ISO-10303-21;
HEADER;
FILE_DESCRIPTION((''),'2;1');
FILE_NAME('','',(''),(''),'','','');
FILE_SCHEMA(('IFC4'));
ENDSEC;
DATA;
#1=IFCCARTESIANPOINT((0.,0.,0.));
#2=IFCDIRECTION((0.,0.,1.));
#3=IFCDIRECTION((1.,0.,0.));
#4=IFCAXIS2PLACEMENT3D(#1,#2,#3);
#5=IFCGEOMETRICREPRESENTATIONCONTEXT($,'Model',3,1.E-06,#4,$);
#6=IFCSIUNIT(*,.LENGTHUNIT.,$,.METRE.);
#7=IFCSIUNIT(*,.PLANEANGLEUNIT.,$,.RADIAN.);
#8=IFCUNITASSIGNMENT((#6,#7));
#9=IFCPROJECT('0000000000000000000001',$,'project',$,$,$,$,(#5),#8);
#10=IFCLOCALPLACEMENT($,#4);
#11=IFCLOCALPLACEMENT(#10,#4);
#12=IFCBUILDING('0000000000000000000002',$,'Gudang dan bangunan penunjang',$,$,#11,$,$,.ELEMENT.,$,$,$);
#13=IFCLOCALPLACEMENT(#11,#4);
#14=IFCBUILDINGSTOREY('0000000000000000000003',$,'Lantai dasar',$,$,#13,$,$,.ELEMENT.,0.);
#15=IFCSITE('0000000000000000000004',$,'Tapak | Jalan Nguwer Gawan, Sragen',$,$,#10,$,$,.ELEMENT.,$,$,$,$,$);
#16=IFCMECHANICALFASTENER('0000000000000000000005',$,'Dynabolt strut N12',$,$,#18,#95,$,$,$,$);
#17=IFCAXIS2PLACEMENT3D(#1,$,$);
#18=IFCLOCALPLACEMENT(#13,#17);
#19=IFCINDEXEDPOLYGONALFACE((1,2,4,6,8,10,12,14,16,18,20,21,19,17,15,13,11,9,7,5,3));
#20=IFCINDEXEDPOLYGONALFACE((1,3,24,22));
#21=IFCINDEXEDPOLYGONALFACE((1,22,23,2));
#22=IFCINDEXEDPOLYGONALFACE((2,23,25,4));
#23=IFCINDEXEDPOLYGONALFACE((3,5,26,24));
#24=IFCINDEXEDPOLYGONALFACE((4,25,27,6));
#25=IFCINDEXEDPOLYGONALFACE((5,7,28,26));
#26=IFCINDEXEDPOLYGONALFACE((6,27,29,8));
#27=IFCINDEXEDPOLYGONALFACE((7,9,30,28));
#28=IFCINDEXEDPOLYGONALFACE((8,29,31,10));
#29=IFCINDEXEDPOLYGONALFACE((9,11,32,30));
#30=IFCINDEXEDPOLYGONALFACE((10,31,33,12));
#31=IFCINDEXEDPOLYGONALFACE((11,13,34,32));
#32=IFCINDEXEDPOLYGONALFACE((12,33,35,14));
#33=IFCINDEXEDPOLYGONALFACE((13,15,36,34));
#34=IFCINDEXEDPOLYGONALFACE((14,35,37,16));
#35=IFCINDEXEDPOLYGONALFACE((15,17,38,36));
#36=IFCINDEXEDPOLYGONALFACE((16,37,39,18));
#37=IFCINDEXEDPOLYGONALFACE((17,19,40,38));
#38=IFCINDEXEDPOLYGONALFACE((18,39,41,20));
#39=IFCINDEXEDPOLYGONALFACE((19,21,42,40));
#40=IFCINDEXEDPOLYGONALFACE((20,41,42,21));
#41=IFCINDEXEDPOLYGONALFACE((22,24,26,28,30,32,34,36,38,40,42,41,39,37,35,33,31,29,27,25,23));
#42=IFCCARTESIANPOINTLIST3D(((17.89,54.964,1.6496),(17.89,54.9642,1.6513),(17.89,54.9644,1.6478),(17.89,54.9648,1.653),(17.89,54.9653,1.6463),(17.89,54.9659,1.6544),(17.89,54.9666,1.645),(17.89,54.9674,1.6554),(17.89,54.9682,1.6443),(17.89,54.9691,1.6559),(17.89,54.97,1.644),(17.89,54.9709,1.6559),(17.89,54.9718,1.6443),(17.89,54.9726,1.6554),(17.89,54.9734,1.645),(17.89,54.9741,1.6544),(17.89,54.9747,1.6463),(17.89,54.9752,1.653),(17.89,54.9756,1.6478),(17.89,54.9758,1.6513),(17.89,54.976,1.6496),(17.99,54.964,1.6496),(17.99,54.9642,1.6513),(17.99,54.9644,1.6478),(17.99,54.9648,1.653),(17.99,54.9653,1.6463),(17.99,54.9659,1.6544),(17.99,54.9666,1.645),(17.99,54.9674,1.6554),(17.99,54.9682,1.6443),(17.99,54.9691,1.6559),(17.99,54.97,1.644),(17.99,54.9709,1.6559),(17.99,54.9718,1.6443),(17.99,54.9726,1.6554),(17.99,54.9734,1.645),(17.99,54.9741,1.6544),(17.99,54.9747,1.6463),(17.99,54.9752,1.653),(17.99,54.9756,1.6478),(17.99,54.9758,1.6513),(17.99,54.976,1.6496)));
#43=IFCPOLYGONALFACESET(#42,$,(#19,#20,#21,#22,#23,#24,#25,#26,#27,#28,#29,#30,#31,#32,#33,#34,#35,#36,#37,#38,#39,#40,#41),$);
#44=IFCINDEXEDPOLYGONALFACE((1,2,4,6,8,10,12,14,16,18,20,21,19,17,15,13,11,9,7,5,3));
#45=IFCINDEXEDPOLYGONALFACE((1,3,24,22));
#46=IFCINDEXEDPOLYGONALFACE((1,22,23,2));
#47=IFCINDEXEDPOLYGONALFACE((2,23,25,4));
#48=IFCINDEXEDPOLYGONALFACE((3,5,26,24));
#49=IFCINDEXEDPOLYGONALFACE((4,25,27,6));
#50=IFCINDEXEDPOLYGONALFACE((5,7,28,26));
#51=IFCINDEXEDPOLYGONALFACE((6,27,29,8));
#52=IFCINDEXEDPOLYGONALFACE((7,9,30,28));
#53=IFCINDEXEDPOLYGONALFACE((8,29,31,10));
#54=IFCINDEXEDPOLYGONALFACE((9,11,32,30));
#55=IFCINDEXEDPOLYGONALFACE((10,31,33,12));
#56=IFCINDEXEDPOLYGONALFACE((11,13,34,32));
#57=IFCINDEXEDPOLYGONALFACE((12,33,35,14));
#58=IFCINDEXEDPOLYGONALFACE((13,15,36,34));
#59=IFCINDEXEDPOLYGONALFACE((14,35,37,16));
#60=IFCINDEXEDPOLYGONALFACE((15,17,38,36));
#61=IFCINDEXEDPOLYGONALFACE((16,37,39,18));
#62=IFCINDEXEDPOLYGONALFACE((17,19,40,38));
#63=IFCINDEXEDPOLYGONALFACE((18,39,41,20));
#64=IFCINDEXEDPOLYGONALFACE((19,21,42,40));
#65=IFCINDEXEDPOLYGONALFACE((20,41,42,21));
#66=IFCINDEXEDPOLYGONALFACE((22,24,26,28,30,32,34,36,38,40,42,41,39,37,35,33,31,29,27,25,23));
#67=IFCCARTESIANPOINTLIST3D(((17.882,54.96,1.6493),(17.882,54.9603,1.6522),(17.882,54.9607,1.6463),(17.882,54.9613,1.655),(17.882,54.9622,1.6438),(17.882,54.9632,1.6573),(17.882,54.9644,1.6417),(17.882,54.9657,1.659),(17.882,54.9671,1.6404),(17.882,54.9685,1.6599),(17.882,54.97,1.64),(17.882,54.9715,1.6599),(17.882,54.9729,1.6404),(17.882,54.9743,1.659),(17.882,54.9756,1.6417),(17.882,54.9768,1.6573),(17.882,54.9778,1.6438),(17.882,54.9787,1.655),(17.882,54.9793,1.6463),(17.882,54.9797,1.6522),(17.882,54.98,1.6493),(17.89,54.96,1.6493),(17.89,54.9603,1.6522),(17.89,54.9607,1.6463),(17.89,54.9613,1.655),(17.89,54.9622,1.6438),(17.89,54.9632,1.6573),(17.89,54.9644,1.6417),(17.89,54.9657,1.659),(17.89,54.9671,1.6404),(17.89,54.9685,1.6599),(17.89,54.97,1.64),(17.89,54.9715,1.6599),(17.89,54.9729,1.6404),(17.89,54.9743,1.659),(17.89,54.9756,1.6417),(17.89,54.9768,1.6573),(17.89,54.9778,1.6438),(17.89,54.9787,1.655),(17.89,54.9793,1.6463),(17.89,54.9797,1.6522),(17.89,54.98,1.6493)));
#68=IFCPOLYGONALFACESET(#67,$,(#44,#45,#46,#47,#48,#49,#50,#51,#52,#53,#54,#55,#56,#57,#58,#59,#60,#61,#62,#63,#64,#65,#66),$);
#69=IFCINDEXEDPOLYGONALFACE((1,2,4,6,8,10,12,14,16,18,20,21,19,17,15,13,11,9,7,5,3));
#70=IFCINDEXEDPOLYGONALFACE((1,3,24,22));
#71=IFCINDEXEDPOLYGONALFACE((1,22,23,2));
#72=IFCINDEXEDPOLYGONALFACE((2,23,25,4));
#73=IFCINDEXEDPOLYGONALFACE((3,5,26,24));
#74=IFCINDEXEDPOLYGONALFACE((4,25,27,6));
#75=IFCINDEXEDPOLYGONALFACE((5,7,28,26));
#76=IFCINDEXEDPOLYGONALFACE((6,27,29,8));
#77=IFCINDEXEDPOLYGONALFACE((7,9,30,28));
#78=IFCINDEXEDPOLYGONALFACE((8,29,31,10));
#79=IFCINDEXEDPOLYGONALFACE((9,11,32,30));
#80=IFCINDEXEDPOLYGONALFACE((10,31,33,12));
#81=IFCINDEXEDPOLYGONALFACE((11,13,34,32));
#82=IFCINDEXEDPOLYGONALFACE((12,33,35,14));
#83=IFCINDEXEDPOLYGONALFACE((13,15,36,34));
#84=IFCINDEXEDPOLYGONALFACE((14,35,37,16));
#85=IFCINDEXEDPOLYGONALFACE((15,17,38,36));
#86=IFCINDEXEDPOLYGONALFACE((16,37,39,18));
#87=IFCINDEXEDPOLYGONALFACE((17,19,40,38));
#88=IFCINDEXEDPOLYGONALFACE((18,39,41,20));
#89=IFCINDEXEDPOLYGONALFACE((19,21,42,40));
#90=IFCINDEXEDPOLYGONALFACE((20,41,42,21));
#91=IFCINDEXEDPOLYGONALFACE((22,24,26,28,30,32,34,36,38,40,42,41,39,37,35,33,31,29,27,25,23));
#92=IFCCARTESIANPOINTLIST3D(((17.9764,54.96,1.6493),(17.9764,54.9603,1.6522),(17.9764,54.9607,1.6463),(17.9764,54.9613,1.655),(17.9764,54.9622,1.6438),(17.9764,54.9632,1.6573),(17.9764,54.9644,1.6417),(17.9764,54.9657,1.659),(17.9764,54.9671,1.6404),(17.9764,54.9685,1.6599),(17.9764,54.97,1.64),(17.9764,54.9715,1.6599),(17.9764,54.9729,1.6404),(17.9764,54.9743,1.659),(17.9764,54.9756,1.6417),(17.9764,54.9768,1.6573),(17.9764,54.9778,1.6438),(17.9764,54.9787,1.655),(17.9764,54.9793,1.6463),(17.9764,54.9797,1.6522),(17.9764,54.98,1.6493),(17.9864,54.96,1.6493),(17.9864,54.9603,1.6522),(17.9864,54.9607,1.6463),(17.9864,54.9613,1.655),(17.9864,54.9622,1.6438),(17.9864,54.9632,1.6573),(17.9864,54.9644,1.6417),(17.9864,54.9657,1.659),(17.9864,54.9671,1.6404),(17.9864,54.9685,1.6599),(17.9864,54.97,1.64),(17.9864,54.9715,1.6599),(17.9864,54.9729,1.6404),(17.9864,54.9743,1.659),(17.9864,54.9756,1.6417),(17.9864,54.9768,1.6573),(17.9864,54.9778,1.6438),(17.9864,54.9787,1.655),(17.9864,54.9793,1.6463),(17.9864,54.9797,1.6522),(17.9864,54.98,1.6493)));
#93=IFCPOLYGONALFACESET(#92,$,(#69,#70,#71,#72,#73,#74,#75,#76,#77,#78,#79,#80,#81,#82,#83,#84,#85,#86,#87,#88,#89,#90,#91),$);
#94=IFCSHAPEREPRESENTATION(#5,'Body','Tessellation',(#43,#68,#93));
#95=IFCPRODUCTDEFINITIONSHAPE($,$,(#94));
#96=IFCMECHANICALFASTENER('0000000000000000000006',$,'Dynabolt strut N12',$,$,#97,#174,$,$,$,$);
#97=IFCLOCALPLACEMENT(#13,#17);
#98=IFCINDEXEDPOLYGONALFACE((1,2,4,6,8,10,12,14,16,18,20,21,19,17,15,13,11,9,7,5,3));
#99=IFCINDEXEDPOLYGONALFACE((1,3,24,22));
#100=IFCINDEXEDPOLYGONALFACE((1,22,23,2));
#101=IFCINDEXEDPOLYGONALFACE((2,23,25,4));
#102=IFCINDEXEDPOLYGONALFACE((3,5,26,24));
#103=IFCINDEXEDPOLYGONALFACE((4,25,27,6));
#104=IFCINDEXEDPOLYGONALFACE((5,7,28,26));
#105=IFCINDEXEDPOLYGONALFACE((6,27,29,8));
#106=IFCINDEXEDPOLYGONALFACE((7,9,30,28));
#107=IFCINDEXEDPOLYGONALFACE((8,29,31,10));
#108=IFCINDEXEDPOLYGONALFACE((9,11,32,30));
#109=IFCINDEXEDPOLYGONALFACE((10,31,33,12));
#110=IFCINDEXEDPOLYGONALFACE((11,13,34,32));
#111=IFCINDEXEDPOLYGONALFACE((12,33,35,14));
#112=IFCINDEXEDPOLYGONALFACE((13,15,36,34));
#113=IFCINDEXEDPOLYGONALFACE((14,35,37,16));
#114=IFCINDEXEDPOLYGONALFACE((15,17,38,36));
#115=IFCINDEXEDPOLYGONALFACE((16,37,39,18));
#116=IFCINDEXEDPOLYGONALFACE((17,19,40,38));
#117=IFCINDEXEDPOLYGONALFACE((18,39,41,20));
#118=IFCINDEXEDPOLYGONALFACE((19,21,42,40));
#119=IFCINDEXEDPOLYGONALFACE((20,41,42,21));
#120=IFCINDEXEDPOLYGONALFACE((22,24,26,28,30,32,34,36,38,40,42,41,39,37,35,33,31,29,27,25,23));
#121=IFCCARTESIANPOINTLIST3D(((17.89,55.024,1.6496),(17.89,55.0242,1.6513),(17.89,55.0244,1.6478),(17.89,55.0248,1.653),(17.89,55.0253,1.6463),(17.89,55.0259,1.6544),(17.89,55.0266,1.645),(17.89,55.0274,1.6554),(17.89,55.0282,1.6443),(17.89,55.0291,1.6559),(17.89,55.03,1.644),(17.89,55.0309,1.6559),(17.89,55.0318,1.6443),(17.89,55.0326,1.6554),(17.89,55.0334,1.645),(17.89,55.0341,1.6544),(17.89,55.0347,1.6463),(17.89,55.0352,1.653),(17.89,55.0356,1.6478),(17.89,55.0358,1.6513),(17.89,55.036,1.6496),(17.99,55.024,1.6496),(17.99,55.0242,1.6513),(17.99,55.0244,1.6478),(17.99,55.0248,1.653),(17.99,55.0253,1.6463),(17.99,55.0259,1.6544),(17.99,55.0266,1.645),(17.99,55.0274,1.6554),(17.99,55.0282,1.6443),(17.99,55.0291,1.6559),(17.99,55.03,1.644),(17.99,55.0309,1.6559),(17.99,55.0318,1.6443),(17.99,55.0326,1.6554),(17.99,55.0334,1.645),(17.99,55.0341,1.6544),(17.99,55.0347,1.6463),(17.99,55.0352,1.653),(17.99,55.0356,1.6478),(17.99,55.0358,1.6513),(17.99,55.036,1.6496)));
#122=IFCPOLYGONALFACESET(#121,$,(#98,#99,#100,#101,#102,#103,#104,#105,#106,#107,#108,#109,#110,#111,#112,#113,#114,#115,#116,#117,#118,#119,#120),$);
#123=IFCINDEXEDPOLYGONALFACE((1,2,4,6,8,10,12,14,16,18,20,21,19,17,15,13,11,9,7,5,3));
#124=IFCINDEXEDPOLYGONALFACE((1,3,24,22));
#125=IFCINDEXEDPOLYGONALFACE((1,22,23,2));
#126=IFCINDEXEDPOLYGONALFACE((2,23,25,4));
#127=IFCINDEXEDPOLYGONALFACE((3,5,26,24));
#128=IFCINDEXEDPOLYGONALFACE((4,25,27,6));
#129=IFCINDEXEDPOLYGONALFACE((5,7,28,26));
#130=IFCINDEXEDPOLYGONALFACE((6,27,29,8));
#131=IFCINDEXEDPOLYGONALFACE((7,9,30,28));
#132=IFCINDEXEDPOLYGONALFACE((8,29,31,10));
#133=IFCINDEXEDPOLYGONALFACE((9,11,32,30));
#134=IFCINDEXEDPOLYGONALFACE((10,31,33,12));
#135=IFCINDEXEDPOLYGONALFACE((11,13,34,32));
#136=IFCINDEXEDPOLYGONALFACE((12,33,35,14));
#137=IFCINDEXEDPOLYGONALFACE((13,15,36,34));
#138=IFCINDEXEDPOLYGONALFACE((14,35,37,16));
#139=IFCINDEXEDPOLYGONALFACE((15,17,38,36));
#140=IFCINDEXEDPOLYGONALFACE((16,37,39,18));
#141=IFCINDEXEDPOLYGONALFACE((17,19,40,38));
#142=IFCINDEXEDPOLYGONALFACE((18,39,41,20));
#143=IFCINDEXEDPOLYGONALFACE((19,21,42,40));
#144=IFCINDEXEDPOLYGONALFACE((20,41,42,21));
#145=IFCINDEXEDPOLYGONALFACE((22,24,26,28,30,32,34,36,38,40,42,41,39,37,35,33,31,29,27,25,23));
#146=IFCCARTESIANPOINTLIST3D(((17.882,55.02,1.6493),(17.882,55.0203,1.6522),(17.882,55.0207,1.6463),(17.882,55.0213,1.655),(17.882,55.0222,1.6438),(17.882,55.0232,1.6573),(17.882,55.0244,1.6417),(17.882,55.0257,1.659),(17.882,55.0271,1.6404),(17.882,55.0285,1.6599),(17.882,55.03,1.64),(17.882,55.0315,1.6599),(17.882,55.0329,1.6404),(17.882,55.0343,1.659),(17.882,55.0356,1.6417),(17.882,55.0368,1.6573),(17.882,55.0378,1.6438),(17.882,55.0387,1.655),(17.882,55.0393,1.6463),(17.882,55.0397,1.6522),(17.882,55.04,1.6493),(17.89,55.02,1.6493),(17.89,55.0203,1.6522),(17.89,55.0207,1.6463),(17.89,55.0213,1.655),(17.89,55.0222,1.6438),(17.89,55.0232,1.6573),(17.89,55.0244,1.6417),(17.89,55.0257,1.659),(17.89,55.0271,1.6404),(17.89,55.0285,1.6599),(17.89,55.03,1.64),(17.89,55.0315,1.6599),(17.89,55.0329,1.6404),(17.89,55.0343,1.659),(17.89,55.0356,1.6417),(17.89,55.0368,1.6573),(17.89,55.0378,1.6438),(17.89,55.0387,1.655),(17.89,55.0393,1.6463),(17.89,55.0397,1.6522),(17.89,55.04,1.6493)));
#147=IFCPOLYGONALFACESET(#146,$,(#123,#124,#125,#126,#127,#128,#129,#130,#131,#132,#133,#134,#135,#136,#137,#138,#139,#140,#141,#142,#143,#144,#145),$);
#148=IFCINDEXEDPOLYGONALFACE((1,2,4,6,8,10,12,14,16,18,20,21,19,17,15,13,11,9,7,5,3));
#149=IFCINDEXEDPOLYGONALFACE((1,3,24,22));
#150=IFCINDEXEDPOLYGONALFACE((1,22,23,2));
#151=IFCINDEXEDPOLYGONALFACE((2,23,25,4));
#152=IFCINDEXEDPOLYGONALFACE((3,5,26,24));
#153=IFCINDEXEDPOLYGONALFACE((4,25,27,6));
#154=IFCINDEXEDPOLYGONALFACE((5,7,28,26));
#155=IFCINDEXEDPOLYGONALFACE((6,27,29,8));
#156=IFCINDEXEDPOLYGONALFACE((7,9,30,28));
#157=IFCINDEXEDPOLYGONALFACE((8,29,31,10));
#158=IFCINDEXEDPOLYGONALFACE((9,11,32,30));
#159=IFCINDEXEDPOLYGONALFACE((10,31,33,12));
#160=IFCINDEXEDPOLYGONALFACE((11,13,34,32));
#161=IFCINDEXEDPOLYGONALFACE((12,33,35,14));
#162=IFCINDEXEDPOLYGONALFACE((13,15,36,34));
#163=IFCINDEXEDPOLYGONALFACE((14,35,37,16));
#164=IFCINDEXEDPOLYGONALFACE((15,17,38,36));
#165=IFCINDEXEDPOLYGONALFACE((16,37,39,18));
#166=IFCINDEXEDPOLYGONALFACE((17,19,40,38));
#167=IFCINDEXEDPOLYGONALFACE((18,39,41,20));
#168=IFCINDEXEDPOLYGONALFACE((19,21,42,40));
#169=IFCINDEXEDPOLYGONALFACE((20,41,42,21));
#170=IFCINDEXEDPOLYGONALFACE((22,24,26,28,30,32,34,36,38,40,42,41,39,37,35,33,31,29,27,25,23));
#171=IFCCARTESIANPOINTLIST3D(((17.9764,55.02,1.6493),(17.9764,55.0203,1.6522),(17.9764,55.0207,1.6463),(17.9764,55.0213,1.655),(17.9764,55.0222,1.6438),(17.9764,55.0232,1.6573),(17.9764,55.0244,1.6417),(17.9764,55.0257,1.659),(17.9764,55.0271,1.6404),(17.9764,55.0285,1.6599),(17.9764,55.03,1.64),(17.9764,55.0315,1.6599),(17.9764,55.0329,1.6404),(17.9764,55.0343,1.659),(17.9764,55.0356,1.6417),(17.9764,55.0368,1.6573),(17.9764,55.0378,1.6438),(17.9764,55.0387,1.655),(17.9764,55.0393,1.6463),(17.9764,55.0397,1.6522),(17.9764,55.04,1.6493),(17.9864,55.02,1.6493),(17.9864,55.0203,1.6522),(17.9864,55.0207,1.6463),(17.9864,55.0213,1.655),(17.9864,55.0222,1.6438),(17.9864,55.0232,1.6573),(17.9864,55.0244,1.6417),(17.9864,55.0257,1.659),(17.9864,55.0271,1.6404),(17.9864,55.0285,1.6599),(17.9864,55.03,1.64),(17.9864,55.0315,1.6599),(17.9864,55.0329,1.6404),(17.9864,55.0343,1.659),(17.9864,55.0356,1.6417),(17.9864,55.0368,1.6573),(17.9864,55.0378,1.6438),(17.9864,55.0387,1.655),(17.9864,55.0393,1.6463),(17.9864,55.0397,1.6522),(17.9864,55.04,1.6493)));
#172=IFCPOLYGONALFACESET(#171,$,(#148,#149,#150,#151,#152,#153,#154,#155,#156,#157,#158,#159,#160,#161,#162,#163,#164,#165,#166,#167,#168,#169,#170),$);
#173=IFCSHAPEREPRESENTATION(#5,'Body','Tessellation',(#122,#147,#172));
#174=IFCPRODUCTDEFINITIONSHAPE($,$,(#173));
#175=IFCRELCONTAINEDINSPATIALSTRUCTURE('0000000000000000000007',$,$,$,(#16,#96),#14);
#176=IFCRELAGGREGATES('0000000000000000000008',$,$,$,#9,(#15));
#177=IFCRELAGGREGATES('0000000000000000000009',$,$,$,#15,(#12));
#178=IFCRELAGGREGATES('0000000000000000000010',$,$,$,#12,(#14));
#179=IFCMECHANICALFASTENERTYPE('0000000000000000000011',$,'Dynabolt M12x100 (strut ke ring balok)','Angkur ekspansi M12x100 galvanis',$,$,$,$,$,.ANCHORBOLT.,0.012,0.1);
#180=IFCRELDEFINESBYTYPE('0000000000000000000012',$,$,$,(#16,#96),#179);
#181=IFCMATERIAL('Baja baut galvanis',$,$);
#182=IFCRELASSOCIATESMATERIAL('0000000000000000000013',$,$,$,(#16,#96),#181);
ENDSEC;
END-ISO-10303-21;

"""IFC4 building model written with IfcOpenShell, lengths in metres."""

from ifc_helpers import new_model, si_unit, frame, origin_with_axes, place, context, project, spatial, circle, extrude, source, transform, mapped, material, type_object, type_shapes, element, save


model = new_model("IFC4")

# Units and contexts
model_context = context("Model", 3, precision=1e-06, world=origin_with_axes())
ifc_project = project(units=[si_unit("LENGTHUNIT", "METRE"), si_unit("PLANEANGLEUNIT", "RADIAN")], contexts=[model_context])

# Site, building, storey
site_placement = place(None, origin_with_axes())
site = spatial("IfcSite", under=ifc_project, at=site_placement, Name="Tapak | Jalan Nguwer Gawan, Sragen", CompositionType="ELEMENT")
building_placement = place(site_placement, origin_with_axes())
building = spatial("IfcBuilding", under=site, at=building_placement, Name="Gudang dan bangunan penunjang", CompositionType="ELEMENT")
storey_placement = place(building_placement, origin_with_axes())
storey = spatial("IfcBuildingStorey", under=building, at=storey_placement, Name="Lantai dasar", CompositionType="ELEMENT", Elevation=0.0)

# Mechanical fasteners
ifc_material = material(Name="Baja baut galvanis")
mechanical_fastener_type = type_object("IfcMechanicalFastenerType", Name="Dynabolt M12x100 (strut ke ring balok)", Description="Angkur ekspansi M12x100 galvanis", NominalDiameter=0.012, NominalLength=0.1, PredefinedType="ANCHORBOLT")
shared_shape = source(origin_with_axes(), model_context, "Body", "SweptSolid", [
    extrude(circle(Radius=0.006), origin_with_axes(), (0.0, 0.0, 1.0), 0.1),
    extrude(circle(Radius=0.01), frame((0.0, 0.0, -0.008), z_axis=(0.0, 0.0, 1.0), x_axis=(1.0, 0.0, 0.0)), (0.0, 0.0, 1.0), 0.008),
    extrude(circle(Radius=0.01), frame((0.0, 0.0, 0.0864), z_axis=(0.0, 0.0, 1.0), x_axis=(1.0, 0.0, 0.0)), (0.0, 0.0, 1.0), 0.01),
])
type_shapes(mechanical_fastener_type, [shared_shape])
placement = place(None, origin_with_axes())
element("IfcMechanicalFastener", 1, at=placement, inside=storey, type_object=mechanical_fastener_type, material=ifc_material, Name="Dynabolt strut N12", context=model_context, shape_type="MappedRepresentation", body=[
    mapped(shared_shape, transform((17.89, 54.97, 1.65), x_axis=(0.0, 0.0, -1.0), y_axis=(0.0, 1.0, 0.0), z_axis=(1.0, 0.0, 0.0), scale=1.0)),
])
element("IfcMechanicalFastener", 2, at=placement, inside=storey, type_object=mechanical_fastener_type, material=ifc_material, Name="Dynabolt strut N12", context=model_context, shape_type="MappedRepresentation", body=[
    mapped(shared_shape, transform((17.89, 55.03, 1.65), x_axis=(0.0, 0.0, -1.0), y_axis=(0.0, 1.0, 0.0), z_axis=(1.0, 0.0, 0.0), scale=1.0)),
])

save(model, "model.ifc")
